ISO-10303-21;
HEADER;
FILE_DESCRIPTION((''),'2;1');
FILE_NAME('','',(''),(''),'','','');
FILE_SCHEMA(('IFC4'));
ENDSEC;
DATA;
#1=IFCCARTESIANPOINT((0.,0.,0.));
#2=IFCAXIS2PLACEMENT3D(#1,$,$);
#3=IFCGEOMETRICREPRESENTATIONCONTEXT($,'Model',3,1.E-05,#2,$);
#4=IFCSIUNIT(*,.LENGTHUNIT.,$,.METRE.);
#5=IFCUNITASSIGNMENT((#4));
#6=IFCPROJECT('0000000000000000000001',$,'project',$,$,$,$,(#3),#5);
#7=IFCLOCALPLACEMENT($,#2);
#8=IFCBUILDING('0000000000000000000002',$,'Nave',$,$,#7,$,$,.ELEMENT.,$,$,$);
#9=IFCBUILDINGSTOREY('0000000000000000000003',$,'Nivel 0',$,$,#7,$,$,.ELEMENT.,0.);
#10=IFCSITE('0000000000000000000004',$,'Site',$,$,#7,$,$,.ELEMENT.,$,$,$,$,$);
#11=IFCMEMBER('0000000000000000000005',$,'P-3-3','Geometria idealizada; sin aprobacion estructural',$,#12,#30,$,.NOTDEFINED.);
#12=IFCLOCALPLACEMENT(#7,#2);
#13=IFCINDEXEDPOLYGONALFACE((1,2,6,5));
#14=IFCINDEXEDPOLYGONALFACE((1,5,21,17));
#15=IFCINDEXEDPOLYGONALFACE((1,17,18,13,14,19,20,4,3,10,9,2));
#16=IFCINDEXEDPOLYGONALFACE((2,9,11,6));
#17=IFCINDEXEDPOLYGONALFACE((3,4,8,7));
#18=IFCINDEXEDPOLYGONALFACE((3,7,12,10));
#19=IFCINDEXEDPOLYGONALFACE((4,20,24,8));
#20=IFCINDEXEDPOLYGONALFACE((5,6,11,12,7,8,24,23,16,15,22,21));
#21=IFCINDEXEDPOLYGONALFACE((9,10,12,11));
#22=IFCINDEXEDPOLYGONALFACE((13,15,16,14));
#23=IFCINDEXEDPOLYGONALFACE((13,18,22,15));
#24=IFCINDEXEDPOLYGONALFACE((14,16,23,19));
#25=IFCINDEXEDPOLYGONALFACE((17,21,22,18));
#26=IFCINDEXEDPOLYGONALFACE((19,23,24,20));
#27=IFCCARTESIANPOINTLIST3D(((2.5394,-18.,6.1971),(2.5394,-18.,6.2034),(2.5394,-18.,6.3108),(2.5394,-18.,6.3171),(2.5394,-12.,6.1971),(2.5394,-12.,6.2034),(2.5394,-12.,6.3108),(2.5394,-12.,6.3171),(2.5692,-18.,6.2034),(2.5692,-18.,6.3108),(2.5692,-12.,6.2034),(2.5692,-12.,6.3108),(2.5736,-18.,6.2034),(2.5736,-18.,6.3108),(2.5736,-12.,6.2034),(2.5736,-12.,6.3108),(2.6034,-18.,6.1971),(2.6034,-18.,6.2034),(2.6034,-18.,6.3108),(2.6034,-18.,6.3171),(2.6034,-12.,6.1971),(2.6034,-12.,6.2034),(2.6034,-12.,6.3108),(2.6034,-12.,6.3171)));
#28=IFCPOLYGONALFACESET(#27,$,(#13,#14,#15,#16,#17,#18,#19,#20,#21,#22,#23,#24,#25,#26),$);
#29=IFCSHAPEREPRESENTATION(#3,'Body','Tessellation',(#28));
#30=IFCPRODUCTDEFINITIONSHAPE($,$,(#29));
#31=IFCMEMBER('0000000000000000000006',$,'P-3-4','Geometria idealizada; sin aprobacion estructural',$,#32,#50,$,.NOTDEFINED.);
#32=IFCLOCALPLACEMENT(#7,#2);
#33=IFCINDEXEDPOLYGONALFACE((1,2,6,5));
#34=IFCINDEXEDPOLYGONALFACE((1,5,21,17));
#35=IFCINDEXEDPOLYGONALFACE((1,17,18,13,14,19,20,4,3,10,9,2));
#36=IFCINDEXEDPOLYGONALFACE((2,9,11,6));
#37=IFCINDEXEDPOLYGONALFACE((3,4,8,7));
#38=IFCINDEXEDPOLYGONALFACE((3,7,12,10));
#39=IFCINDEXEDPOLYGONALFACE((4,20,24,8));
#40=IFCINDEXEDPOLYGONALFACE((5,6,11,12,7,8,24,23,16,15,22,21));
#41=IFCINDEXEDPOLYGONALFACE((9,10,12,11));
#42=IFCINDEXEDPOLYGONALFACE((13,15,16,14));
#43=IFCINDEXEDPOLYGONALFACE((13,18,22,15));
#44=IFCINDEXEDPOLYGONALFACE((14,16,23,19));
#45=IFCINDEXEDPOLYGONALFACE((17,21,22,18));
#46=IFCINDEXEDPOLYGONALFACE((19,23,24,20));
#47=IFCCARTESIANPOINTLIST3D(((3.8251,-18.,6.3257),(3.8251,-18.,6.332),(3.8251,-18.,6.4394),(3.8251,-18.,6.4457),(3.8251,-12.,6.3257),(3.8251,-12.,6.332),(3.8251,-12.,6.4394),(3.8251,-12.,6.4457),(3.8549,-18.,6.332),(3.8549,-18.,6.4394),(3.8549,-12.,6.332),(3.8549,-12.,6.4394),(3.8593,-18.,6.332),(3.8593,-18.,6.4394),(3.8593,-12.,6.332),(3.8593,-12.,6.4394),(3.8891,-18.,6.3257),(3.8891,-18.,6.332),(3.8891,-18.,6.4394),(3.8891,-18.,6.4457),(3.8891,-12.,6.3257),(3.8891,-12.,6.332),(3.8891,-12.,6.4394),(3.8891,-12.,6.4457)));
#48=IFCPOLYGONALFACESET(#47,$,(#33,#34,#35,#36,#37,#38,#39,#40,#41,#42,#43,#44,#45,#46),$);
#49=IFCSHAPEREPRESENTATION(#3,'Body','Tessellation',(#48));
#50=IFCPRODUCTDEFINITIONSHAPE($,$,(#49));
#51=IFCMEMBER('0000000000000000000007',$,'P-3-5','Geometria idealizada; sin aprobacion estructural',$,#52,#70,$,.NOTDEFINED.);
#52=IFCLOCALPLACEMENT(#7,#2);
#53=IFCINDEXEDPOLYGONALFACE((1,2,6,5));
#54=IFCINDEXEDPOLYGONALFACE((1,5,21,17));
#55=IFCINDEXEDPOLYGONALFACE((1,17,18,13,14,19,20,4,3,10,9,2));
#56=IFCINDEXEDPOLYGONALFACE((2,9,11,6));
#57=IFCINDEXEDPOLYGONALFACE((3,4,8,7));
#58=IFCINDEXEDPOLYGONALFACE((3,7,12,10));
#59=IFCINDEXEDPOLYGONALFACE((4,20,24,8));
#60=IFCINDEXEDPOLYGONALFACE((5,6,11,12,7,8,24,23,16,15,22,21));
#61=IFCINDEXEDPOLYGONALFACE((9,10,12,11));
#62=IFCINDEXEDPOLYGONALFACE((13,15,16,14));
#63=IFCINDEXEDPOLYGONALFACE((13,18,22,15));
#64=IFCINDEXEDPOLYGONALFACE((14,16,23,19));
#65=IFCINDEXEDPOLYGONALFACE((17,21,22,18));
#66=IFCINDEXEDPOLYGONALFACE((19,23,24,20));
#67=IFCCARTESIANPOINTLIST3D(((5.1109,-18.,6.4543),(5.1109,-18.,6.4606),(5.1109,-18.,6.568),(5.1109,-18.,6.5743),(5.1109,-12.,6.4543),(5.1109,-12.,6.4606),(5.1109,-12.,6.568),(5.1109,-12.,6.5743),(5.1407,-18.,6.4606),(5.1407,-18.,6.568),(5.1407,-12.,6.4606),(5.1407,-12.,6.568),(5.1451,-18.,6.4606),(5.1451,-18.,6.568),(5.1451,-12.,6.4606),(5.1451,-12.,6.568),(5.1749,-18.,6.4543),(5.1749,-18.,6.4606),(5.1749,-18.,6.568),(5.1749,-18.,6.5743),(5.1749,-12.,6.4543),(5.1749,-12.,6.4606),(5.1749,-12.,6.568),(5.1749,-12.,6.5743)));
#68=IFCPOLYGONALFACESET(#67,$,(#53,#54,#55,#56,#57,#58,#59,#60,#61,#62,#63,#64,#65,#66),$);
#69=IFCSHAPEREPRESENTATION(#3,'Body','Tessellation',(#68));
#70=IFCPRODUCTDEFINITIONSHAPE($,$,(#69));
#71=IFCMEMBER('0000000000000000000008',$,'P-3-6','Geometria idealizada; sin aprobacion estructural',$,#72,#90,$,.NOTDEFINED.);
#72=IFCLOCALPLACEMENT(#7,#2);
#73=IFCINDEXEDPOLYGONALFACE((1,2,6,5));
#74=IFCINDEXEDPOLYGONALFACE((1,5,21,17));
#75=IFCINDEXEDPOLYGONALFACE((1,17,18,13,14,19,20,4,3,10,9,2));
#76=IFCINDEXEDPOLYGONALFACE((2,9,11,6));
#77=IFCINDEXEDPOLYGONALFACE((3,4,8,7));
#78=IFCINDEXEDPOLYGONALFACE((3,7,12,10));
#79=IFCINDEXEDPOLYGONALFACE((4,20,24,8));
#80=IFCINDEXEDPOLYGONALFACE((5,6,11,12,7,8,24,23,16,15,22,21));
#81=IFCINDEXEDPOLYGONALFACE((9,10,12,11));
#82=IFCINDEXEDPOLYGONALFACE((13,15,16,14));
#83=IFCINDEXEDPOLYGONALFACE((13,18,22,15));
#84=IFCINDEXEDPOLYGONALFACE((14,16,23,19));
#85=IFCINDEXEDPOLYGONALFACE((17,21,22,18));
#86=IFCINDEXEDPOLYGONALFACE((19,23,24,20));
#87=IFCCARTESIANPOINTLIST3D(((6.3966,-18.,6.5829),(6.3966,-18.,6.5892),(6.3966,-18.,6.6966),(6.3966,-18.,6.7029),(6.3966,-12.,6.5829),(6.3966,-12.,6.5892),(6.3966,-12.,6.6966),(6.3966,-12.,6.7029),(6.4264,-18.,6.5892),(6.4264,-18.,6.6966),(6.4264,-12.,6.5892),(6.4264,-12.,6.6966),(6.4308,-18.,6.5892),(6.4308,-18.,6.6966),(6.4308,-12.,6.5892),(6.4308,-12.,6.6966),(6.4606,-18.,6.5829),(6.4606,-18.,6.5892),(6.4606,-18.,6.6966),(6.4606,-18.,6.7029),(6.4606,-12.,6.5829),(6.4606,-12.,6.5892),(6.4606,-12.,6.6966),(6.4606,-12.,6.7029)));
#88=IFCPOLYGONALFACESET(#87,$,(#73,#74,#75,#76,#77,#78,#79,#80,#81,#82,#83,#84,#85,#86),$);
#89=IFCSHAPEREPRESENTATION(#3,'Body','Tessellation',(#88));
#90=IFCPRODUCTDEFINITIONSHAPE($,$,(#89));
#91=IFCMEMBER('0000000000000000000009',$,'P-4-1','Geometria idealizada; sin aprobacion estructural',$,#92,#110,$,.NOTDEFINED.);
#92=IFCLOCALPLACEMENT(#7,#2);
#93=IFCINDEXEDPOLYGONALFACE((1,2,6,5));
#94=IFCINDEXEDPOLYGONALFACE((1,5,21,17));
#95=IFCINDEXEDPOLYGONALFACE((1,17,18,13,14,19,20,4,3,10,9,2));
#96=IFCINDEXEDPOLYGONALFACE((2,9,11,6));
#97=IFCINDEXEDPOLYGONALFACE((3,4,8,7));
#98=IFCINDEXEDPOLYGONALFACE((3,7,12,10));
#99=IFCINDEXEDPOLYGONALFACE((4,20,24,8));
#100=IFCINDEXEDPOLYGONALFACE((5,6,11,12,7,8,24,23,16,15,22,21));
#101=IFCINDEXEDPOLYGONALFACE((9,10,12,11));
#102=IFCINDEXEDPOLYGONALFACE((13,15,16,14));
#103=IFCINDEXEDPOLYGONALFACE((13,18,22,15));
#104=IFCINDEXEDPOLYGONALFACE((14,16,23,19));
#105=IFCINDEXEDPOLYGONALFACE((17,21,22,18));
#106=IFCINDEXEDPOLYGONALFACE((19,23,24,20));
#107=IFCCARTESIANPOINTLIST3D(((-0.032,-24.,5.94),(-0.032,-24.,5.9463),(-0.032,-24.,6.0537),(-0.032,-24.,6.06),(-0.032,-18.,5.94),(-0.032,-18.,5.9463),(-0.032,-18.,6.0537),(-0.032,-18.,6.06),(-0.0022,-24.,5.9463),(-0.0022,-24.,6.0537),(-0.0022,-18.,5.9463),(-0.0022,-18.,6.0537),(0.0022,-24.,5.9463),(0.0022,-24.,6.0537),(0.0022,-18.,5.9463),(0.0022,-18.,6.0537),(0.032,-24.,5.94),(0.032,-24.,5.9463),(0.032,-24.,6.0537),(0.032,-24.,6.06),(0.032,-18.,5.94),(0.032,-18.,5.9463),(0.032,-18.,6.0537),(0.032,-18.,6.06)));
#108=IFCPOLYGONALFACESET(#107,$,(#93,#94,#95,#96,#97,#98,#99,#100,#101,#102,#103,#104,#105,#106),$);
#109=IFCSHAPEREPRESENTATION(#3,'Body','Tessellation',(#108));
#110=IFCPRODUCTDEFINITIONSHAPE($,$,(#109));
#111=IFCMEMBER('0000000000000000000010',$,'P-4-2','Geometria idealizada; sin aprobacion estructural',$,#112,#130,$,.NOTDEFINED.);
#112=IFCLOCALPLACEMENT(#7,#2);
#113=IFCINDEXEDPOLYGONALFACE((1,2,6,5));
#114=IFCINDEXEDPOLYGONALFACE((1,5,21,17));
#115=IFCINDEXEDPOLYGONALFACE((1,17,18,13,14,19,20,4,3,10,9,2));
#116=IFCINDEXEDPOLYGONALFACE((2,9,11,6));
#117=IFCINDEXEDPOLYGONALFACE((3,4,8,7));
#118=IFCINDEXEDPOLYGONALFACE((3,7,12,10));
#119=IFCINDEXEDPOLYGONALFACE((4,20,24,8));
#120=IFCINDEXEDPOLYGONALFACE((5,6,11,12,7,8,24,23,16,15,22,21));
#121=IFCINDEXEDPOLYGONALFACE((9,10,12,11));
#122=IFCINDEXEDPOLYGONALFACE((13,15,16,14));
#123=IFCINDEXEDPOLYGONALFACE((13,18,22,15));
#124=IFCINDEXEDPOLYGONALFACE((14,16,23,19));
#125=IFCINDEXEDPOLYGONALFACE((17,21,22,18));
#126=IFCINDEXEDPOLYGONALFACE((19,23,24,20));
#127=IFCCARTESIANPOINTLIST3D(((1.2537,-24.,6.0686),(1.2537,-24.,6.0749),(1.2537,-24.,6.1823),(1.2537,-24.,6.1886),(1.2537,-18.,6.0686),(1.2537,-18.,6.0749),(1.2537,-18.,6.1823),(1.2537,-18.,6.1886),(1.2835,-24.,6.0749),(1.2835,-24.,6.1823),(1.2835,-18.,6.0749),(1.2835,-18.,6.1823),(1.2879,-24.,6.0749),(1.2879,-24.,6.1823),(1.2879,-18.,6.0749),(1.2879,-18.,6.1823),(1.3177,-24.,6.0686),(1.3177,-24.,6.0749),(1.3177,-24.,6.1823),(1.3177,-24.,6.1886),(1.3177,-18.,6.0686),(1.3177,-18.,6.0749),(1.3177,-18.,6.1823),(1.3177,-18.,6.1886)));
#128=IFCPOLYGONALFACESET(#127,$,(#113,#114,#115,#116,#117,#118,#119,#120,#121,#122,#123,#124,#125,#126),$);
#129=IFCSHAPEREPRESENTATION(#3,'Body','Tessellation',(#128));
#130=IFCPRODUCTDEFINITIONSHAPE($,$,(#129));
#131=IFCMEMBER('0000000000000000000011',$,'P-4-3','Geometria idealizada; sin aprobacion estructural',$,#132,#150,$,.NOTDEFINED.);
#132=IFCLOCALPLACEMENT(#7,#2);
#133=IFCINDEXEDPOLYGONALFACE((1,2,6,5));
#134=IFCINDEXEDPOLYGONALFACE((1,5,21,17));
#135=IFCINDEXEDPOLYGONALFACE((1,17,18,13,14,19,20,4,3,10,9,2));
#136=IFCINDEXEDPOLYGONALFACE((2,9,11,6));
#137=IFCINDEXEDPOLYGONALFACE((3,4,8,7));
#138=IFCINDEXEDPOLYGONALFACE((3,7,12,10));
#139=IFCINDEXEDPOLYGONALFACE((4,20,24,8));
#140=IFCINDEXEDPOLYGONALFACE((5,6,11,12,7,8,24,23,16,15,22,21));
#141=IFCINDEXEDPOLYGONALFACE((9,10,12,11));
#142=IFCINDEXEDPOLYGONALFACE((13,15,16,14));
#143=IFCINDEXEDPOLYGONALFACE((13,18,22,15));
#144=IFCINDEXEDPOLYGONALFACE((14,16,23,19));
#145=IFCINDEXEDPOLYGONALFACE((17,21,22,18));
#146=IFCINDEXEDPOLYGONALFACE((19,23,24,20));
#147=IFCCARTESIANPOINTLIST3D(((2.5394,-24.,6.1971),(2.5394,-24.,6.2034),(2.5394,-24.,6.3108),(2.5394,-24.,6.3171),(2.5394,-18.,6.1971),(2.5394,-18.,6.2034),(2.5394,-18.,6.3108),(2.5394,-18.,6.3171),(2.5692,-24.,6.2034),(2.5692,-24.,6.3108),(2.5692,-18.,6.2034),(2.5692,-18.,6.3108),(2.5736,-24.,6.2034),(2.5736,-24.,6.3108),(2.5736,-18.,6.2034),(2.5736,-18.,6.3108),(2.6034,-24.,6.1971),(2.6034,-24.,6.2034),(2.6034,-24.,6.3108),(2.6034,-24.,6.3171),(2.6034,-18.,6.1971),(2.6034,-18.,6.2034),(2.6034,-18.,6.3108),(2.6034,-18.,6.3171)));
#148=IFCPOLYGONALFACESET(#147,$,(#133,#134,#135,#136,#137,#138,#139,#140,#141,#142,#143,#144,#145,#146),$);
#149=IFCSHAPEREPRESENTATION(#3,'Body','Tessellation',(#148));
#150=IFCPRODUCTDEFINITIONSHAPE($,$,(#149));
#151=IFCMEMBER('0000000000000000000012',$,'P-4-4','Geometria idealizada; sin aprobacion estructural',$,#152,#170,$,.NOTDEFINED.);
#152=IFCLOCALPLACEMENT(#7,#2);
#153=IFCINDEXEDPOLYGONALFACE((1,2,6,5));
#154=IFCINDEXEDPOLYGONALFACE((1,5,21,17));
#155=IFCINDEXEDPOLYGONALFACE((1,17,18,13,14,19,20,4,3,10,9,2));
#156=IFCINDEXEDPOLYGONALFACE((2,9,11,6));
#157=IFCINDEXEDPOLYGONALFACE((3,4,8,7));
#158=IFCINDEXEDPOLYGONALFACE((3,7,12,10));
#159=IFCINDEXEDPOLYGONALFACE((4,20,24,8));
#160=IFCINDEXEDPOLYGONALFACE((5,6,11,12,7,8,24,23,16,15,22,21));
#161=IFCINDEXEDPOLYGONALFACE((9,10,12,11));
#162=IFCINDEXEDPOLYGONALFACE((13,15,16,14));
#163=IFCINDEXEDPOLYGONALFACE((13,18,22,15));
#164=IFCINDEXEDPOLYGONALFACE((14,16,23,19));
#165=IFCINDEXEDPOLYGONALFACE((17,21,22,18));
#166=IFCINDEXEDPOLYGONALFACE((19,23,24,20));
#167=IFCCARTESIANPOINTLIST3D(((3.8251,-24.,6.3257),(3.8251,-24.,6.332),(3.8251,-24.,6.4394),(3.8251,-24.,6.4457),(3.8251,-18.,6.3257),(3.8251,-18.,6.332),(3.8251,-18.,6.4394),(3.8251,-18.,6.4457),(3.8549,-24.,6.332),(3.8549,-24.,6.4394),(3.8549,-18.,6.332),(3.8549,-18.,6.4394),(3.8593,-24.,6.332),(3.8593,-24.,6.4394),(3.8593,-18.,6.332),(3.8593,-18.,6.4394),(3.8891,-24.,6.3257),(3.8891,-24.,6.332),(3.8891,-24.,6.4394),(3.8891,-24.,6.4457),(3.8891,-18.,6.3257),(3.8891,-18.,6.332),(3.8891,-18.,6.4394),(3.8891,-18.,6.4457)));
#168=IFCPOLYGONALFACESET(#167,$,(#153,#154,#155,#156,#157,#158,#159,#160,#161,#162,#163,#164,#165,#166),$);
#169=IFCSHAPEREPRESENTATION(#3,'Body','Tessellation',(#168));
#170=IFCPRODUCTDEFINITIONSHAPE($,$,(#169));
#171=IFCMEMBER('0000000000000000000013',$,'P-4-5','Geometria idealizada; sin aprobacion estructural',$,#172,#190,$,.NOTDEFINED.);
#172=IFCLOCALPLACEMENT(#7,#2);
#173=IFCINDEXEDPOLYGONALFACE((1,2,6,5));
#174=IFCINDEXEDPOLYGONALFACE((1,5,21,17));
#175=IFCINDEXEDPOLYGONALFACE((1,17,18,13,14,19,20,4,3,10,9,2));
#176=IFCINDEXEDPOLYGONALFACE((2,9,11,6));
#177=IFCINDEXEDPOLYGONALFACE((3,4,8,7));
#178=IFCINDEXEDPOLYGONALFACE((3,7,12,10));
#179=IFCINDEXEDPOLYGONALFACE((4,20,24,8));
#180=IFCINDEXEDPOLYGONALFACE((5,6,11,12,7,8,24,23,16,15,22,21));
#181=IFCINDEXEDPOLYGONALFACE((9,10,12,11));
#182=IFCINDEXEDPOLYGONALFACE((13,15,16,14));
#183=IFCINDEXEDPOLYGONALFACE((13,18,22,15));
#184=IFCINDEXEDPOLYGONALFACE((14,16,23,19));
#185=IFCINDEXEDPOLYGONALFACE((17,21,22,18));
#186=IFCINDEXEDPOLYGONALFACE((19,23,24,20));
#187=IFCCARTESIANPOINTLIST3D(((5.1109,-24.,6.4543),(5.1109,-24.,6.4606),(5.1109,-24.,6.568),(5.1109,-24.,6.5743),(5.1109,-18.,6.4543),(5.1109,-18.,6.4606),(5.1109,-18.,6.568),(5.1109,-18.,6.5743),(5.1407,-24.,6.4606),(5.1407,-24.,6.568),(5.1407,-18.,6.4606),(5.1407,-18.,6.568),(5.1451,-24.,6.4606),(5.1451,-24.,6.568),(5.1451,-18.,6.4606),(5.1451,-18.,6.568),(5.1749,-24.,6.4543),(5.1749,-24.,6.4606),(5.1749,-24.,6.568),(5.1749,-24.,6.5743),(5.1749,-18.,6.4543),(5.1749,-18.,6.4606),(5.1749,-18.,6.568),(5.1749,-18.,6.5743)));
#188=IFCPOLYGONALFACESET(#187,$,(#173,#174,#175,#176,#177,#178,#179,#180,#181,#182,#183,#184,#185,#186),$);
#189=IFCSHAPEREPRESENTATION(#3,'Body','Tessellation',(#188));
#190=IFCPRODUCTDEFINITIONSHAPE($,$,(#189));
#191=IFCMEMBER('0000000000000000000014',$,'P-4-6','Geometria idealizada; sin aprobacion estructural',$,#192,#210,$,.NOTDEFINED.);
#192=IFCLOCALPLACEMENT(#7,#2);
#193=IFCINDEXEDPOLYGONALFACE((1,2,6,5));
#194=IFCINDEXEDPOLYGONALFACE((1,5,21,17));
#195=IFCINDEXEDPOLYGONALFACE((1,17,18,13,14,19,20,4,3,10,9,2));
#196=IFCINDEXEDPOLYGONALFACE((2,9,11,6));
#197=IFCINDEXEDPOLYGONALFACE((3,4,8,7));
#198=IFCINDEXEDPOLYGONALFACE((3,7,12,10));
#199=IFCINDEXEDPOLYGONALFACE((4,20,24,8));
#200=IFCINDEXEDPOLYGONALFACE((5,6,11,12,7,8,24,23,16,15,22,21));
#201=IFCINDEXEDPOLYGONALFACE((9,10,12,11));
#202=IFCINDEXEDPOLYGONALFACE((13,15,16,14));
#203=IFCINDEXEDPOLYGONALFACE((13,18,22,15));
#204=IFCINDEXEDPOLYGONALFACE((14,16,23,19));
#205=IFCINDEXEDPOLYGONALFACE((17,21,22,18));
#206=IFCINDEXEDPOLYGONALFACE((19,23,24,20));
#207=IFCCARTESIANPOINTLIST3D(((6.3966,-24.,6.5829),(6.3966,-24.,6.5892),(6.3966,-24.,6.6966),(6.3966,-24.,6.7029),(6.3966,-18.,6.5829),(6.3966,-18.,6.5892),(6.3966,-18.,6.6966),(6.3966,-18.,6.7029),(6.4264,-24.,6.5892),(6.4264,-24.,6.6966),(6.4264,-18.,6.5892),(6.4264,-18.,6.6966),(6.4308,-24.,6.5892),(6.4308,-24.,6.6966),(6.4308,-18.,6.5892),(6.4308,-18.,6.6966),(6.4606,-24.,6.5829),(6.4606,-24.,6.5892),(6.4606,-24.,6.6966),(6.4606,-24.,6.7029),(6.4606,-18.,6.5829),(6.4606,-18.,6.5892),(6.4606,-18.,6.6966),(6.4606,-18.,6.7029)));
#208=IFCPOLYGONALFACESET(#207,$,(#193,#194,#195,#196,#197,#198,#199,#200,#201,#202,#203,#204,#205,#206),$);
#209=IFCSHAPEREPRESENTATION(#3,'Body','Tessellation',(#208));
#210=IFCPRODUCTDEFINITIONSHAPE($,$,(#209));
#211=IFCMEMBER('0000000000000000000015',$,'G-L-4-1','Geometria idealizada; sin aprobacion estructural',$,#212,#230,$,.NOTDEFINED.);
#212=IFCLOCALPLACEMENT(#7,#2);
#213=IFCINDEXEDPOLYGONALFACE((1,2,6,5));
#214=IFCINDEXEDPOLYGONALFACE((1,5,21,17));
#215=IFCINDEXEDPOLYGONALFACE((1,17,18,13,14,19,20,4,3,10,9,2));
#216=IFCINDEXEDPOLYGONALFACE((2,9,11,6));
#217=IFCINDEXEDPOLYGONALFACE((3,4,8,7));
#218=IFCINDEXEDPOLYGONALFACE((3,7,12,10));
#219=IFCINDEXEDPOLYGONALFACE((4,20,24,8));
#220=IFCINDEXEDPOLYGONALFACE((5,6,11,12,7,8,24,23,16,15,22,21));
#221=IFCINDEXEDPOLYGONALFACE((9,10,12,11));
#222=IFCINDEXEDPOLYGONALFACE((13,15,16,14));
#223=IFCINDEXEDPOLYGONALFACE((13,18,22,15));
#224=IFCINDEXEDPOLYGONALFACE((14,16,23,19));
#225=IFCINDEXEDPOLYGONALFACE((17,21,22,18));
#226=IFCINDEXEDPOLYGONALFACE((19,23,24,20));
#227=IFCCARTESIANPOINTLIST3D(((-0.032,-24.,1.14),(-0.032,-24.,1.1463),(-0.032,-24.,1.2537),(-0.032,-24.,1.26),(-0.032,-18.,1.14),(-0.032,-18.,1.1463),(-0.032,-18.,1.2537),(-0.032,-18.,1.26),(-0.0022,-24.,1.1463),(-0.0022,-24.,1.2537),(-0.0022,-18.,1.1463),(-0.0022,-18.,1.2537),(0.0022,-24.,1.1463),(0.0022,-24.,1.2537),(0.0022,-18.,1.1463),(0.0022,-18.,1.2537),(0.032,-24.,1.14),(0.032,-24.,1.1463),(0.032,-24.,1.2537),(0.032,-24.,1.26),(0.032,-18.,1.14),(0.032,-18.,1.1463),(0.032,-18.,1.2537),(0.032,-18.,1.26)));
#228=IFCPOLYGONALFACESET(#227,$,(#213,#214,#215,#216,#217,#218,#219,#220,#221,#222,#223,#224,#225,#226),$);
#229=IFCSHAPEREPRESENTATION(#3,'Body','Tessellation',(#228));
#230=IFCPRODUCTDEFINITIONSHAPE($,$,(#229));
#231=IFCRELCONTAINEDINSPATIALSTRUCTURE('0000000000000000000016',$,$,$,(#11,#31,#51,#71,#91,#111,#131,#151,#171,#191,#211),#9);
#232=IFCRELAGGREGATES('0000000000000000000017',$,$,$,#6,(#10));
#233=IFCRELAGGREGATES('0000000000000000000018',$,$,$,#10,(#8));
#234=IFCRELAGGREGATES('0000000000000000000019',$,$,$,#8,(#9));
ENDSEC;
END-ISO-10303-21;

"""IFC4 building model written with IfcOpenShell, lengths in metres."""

from ifc_helpers import new_model, si_unit, frame, origin, place, context, project, spatial, polyline, outline, extrude, element, save


model = new_model("IFC4")

# Units and contexts
model_context = context("Model", 3, precision=1e-05, world=origin())
ifc_project = project(units=[si_unit("LENGTHUNIT", "METRE")], contexts=[model_context])

# Site, building, storey
placement = place(None, origin())
site = spatial("IfcSite", under=ifc_project, at=placement, Name="Site", CompositionType="ELEMENT")
building = spatial("IfcBuilding", under=site, at=placement, Name="Nave", CompositionType="ELEMENT")
storey = spatial("IfcBuildingStorey", under=building, at=placement, Name="Nivel 0", CompositionType="ELEMENT", Elevation=0.0)

# Members
for number, where, z_axis, x_axis, name in (
    (1, (2.5714, -12.0, 6.2571), (0.0, -1.0, 0.0), (1.0, 0.0, 0.0), "P-3-3"),
    (2, (3.8571, -12.0, 6.3857), (0.0, -1.0, 0.0), (1.0, 0.0, 0.0), "P-3-4"),
    (3, (5.1429, -12.0, 6.5143), (0.0, -1.0, 0.0), (1.0, 0.0, 0.0), "P-3-5"),
    (4, (6.4286, -12.0, 6.6429), (0.0, -1.0, 0.0), (1.0, 0.0, 0.0), "P-3-6"),
    (5, (0.0, -18.0, 6.0), (0.0, -1.0, 0.0), (1.0, 0.0, 0.0), "P-4-1"),
    (6, (1.2857, -18.0, 6.1286), (0.0, -1.0, 0.0), (1.0, 0.0, 0.0), "P-4-2"),
    (7, (2.5714, -18.0, 6.2571), (0.0, -1.0, 0.0), (1.0, 0.0, 0.0), "P-4-3"),
    (8, (3.8571, -18.0, 6.3857), (0.0, -1.0, 0.0), (1.0, 0.0, 0.0), "P-4-4"),
    (9, (5.1429, -18.0, 6.5143), (0.0, -1.0, 0.0), (1.0, 0.0, 0.0), "P-4-5"),
    (10, (6.4286, -18.0, 6.6429), (0.0, -1.0, 0.0), (1.0, 0.0, 0.0), "P-4-6"),
    (11, (0.0, -18.0, 1.2), (0.0, -1.0, 0.0), (1.0, 0.0, 0.0), "G-L-4-1"),
):
    element("IfcMember", number, at=place(placement, frame(where, z_axis=z_axis, x_axis=x_axis)), inside=storey, Name=name, Description="Geometria idealizada; sin aprobacion estructural", PredefinedType="NOTDEFINED", context=model_context, shape_type="SweptSolid", body=[
        extrude(outline(polyline([(-0.032, -0.06), (0.032, -0.06), (0.032, -0.0537), (0.0022, -0.0537), (0.0022, 0.0537), (0.032, 0.0537), (0.032, 0.06), (-0.032, 0.06), (-0.032, 0.0537), (-0.0022, 0.0537), (-0.0022, -0.0537), (-0.032, -0.0537), (-0.032, -0.06)])), origin(), (0.0, 0.0, 1.0), 6.0),
    ])

save(model, "model.ifc")
